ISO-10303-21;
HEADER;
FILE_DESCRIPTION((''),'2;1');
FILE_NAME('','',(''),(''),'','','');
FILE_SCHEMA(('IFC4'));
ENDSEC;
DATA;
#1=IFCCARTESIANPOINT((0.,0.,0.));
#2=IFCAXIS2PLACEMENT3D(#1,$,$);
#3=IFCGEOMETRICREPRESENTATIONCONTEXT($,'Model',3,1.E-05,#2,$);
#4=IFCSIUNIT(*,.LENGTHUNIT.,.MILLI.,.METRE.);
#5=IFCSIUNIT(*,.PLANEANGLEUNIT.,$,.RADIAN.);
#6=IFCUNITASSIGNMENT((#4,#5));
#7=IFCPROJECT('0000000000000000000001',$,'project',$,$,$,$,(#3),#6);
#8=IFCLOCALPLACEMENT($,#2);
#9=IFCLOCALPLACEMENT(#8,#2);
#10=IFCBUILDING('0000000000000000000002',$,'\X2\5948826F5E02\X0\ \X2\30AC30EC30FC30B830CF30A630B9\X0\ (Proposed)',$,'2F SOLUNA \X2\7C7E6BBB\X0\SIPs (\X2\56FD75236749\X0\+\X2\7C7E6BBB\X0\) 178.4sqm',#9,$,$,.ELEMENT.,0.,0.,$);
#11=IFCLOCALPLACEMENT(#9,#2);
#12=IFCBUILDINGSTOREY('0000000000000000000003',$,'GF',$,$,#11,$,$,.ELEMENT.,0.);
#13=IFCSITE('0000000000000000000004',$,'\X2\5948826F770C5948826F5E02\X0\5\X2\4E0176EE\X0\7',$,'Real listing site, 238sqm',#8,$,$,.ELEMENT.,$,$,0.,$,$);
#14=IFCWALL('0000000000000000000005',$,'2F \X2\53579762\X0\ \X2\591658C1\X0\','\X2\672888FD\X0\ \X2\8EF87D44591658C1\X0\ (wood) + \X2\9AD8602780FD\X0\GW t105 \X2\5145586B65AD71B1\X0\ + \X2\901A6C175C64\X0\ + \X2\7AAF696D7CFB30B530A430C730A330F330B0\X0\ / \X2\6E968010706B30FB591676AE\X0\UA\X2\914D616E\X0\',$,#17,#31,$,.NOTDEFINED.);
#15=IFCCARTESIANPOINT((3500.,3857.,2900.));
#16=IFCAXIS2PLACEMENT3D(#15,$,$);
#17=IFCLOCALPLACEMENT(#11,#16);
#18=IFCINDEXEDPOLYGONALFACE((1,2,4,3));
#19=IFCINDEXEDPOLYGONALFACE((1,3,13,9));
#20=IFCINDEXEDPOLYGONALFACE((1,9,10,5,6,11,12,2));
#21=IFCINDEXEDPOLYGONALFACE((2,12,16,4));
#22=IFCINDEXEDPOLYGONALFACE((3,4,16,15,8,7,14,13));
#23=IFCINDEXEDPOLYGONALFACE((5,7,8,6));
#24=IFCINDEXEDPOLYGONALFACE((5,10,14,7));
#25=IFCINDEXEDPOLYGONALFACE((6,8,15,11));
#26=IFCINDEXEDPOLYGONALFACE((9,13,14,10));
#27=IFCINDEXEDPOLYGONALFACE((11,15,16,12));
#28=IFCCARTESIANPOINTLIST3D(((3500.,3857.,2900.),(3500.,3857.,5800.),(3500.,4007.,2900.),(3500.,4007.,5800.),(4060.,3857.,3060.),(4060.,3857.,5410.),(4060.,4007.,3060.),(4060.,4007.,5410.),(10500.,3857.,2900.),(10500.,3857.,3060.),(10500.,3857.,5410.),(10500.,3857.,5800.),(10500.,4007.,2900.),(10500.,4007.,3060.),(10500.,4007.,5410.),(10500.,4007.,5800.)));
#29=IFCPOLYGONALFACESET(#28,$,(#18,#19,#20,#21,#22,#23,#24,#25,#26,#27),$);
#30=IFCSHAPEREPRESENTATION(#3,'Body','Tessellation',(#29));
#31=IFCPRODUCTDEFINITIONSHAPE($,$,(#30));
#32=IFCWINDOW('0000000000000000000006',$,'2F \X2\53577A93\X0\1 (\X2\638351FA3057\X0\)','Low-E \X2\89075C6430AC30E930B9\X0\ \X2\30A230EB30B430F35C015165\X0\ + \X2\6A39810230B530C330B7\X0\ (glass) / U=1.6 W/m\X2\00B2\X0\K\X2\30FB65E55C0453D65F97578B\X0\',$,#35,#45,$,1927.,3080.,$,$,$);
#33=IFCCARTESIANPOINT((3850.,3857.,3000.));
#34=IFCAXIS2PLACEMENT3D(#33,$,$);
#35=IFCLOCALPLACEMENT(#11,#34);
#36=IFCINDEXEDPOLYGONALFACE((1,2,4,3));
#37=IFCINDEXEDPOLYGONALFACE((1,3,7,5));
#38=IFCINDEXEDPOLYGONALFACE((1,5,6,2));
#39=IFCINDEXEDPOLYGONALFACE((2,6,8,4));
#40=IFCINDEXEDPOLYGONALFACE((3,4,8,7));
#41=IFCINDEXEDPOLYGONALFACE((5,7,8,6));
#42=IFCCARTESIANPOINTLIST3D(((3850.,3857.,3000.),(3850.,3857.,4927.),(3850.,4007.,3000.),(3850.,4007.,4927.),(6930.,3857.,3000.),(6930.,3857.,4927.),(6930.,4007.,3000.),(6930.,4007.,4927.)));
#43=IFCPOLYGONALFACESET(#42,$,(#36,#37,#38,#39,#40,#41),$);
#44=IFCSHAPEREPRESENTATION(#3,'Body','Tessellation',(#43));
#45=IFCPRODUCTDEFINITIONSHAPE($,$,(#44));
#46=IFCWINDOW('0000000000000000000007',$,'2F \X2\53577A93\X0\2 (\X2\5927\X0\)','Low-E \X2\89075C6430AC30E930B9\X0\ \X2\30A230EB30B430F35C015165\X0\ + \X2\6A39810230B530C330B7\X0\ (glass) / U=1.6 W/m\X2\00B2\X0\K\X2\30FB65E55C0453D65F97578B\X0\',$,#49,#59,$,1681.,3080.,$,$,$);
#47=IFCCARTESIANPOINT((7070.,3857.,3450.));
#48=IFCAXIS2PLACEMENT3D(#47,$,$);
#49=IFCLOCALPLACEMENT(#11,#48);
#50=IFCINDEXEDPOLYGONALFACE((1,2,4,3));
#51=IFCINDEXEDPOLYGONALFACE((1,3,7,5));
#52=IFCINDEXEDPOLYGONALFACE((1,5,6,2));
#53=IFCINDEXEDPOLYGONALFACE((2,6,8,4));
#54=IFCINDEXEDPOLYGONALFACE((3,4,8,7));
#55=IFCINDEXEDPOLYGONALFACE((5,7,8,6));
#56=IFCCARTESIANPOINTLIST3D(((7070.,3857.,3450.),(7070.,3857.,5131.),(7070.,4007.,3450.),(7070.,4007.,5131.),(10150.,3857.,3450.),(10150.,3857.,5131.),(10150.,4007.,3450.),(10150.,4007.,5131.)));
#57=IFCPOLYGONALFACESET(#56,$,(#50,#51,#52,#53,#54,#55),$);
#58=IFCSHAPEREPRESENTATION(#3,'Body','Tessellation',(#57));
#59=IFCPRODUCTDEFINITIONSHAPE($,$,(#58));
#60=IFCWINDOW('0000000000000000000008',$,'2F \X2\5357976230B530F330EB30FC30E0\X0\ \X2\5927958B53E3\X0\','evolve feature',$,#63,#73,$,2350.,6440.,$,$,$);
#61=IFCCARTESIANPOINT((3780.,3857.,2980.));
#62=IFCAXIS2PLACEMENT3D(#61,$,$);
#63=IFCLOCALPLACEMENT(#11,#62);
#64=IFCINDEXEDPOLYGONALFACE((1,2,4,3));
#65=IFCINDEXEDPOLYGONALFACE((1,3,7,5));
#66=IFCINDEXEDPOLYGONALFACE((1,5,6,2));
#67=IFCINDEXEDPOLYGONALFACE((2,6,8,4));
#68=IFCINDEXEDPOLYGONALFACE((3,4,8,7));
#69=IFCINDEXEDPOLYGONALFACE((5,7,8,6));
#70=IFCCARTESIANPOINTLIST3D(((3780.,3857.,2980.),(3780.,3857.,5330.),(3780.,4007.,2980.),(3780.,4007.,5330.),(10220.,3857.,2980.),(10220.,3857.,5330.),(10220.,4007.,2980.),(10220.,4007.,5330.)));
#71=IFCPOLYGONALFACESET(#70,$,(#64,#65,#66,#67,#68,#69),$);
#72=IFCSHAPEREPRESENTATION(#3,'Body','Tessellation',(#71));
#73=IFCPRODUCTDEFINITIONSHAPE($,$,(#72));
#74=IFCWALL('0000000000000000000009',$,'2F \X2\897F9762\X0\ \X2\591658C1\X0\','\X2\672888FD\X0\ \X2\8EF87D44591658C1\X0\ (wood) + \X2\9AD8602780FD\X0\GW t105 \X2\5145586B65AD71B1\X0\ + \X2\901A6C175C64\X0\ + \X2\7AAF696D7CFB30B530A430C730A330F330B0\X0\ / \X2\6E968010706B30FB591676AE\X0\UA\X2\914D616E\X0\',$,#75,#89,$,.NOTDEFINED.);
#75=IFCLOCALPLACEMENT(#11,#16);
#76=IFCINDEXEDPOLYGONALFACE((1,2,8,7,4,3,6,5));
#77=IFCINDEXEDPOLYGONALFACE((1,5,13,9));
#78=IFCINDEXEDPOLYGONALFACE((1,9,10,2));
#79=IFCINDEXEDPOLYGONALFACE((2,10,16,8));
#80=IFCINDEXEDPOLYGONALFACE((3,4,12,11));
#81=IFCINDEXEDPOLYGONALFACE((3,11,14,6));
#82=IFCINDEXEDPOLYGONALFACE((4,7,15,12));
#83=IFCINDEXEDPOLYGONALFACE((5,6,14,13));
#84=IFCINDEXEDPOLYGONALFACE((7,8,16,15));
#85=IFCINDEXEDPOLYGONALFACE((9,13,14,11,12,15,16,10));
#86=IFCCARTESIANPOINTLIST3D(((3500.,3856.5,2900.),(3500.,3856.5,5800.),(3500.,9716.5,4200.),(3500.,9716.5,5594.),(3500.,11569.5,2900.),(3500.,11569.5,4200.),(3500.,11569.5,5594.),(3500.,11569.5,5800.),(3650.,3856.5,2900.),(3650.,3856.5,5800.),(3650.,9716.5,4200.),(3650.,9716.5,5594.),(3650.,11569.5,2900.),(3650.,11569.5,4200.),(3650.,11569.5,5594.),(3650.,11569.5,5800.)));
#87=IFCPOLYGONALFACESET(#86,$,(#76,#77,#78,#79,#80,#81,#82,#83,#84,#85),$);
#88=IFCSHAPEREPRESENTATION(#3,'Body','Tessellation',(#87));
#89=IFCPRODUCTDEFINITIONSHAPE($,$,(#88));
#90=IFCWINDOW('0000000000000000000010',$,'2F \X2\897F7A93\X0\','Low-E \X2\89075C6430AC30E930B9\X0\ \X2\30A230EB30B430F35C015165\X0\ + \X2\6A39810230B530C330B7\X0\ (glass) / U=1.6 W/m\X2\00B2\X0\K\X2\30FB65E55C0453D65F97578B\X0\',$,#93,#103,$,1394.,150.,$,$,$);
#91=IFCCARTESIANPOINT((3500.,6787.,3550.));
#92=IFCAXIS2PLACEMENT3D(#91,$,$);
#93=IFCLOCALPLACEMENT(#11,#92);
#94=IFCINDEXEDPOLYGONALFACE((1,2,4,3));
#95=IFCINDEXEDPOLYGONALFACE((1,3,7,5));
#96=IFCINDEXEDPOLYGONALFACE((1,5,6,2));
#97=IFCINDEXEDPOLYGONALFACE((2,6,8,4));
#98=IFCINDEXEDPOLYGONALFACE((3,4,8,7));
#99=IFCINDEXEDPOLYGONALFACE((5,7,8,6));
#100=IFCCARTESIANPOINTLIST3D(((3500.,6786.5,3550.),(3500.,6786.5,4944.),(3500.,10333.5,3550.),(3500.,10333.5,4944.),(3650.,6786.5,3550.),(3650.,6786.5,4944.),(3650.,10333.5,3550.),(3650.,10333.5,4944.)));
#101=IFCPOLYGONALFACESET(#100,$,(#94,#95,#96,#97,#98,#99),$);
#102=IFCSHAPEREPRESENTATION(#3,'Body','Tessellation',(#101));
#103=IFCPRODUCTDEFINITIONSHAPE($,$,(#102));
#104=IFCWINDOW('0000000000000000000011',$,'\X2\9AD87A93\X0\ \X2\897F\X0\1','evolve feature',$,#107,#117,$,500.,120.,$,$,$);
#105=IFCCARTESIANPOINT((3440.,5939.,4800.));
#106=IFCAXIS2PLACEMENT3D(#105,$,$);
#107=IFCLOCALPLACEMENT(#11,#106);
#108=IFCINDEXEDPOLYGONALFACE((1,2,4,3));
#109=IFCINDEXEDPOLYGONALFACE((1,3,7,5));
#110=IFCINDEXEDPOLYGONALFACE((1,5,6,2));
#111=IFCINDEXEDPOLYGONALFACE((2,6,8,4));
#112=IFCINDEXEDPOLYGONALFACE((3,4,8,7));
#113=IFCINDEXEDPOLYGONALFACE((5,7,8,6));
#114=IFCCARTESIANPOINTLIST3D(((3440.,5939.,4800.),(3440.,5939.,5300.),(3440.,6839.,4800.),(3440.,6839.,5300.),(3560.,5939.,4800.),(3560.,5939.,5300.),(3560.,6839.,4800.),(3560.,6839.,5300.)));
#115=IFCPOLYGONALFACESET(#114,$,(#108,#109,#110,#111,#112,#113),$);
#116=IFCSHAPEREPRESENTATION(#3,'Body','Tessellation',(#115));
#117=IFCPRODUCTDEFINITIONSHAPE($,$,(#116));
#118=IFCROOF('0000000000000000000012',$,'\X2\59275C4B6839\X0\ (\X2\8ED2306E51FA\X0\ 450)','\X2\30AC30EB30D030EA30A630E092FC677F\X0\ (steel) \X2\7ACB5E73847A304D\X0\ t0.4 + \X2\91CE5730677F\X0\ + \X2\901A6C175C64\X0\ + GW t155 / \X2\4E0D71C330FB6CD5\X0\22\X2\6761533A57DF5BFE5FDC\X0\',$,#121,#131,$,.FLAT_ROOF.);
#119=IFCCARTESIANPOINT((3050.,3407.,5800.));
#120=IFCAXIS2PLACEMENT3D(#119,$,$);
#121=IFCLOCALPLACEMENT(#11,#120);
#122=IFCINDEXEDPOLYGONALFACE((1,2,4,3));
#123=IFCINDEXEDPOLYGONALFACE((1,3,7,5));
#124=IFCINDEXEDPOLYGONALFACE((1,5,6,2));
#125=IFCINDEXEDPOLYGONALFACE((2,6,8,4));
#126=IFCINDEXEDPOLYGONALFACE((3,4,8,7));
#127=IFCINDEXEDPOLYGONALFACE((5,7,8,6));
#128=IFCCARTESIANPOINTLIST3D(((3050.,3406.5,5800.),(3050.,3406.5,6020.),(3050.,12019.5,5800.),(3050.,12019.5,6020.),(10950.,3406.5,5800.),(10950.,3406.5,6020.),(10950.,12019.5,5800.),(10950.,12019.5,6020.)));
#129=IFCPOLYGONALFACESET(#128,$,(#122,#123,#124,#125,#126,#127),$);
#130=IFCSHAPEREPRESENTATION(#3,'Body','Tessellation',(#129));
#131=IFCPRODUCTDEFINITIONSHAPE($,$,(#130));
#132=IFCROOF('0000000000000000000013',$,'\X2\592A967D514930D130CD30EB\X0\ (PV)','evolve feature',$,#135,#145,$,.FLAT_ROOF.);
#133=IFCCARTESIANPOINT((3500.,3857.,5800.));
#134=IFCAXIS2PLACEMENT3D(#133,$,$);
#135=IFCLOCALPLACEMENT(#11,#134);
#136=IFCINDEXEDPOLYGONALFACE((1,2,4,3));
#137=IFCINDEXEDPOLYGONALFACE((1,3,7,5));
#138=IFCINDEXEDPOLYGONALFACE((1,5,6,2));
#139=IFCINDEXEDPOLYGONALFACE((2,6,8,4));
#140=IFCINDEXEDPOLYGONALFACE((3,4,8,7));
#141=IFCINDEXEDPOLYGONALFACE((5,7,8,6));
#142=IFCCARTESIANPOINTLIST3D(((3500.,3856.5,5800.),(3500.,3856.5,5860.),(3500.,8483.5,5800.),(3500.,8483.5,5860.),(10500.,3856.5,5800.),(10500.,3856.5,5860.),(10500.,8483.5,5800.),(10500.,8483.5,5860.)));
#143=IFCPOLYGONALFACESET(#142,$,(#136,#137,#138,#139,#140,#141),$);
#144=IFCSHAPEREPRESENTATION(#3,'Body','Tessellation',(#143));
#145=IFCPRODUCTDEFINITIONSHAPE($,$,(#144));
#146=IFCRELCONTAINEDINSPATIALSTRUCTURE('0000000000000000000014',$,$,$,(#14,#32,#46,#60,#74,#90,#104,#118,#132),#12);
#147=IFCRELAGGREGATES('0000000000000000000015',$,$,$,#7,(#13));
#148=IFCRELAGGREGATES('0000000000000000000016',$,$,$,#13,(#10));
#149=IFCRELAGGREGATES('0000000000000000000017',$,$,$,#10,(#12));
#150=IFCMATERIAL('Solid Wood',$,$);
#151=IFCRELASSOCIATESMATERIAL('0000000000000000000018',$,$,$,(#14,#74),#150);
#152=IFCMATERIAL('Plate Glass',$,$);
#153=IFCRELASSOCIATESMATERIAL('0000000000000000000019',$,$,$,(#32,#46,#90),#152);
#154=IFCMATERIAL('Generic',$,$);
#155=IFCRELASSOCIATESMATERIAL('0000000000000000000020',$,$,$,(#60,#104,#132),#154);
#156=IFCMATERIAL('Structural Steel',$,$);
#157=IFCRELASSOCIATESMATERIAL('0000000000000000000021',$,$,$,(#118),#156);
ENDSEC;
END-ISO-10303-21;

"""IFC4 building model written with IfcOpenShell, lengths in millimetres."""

from ifc_helpers import new_model, si_unit, frame, frame_2d, origin, place, context, project, spatial, rectangle, extrude, material, element, fill, save


model = new_model("IFC4")

# Units and contexts
model_context = context("Model", 3, precision=1e-05, world=origin())
ifc_project = project(units=[si_unit("LENGTHUNIT", "METRE", prefix="MILLI"), si_unit("PLANEANGLEUNIT", "RADIAN")], contexts=[model_context])

# Site, building, storey
site_placement = place(None, origin())
site = spatial("IfcSite", under=ifc_project, at=site_placement, Name="奈良県奈良市5丁目7", ObjectType="Real listing site, 238sqm", CompositionType="ELEMENT", RefElevation=0.0)
building_placement = place(site_placement, origin())
building = spatial("IfcBuilding", under=site, at=building_placement, Name="奈良市 ガレージハウス (Proposed)", ObjectType="2F SOLUNA 籾殻SIPs (国産杉+籾殻) 178.4sqm", CompositionType="ELEMENT", ElevationOfRefHeight=0.0, ElevationOfTerrain=0.0)
storey_placement = place(building_placement, origin())
storey = spatial("IfcBuildingStorey", under=building, at=storey_placement, Name="GF", CompositionType="ELEMENT", Elevation=0.0)

# Shared definitions
ifc_material_1 = material(Name="Solid Wood")
ifc_material_2 = material(Name="Generic")

# Shared definitions
ifc_material_3 = material(Name="Plate Glass")

# Walls, openings, windows
wall_1_placement = place(storey_placement, frame((3500.0, 3857.0, 2900.0)))
wall_1 = element("IfcWall", 1, at=wall_1_placement, inside=storey, material=ifc_material_1, Name="2F 南面 外壁", Description="木製 軸組外壁 (wood) + 高性能GW t105 充填断熱 + 通気層 + 窯業系サイディング / 準耐火・外皮UA配慮", PredefinedType="NOTDEFINED", context=model_context, shape_type="SweptSolid", body=[
    extrude(rectangle(XDim=7000.0, YDim=150.0, at=frame_2d((3500.0, 75.0))), frame((3500.0, 3857.0, 2900.0)), (0.0, 0.0, 1.0), 2900.0),
])
opening_1_placement = place(storey_placement, frame((3850.0, 3857.0, 3000.0)))
opening_1 = element("IfcOpeningElement", 2, at=opening_1_placement, cuts=wall_1, PredefinedType="NOTDEFINED", context=model_context, shape_type="SweptSolid", body=[
    extrude(rectangle(XDim=3080.0, YDim=150.0, at=frame_2d((1540.0, 75.0))), frame((3850.0, 3857.0, 3000.0)), (0.0, 0.0, 1.0), 1927.0),
])
opening_2_placement = place(storey_placement, frame((7070.0, 3857.0, 3450.0)))
opening_2 = element("IfcOpeningElement", 3, at=opening_2_placement, cuts=wall_1, PredefinedType="NOTDEFINED", context=model_context, shape_type="SweptSolid", body=[
    extrude(rectangle(XDim=3080.0, YDim=150.0, at=frame_2d((1540.0, 75.0))), frame((7070.0, 3857.0, 3450.0)), (0.0, 0.0, 1.0), 1681.0),
])
opening_3_placement = place(storey_placement, frame((3780.0, 3857.0, 2980.0)))
opening_3 = element("IfcOpeningElement", 4, at=opening_3_placement, cuts=wall_1, PredefinedType="NOTDEFINED", context=model_context, shape_type="SweptSolid", body=[
    extrude(rectangle(XDim=6440.0, YDim=150.0, at=frame_2d((3220.0, 75.0))), frame((3780.0, 3857.0, 2980.0)), (0.0, 0.0, 1.0), 2350.0),
])
window_1_placement = place(storey_placement, frame((3850.0, 3857.0, 3000.0)))
window_1 = element("IfcWindow", 5, at=window_1_placement, inside=storey, material=ifc_material_3, Name="2F 南窓1 (掃出し)", Description="Low-E 複層ガラス アルゴン封入 + 樹脂サッシ (glass) / U=1.6 W/m²K・日射取得型", OverallHeight=1927.0, OverallWidth=3080.0, context=model_context, shape_type="SweptSolid", body=[
    extrude(rectangle(XDim=3080.0, YDim=150.0, at=frame_2d((1540.0, 75.0))), frame((3850.0, 3857.0, 3000.0)), (0.0, 0.0, 1.0), 1927.0),
])
fill(opening_1, window_1)
window_2_placement = place(storey_placement, frame((7070.0, 3857.0, 3450.0)))
window_2 = element("IfcWindow", 6, at=window_2_placement, inside=storey, material=ifc_material_3, Name="2F 南窓2 (大)", Description="Low-E 複層ガラス アルゴン封入 + 樹脂サッシ (glass) / U=1.6 W/m²K・日射取得型", OverallHeight=1681.0, OverallWidth=3080.0, context=model_context, shape_type="SweptSolid", body=[
    extrude(rectangle(XDim=3080.0, YDim=150.0, at=frame_2d((1540.0, 75.0))), frame((7070.0, 3857.0, 3450.0)), (0.0, 0.0, 1.0), 1681.0),
])
fill(opening_2, window_2)
window_3_placement = place(storey_placement, frame((3780.0, 3857.0, 2980.0)))
window_3 = element("IfcWindow", 7, at=window_3_placement, inside=storey, material=ifc_material_2, Name="2F 南面サンルーム 大開口", Description="evolve feature", OverallHeight=2350.0, OverallWidth=6440.0, context=model_context, shape_type="SweptSolid", body=[
    extrude(rectangle(XDim=6440.0, YDim=150.0, at=frame_2d((3220.0, 75.0))), frame((3780.0, 3857.0, 2980.0)), (0.0, 0.0, 1.0), 2350.0),
])
fill(opening_3, window_3)
wall_2_placement = place(storey_placement, frame((3500.0, 3857.0, 2900.0)))
wall_2 = element("IfcWall", 8, at=wall_2_placement, inside=storey, material=ifc_material_1, Name="2F 西面 外壁", Description="木製 軸組外壁 (wood) + 高性能GW t105 充填断熱 + 通気層 + 窯業系サイディング / 準耐火・外皮UA配慮", PredefinedType="NOTDEFINED", context=model_context, shape_type="SweptSolid", body=[
    extrude(rectangle(XDim=150.0, YDim=7713.0, at=frame_2d((75.0, 3856.0))), frame((3500.0, 3857.0, 2900.0)), (0.0, 0.0, 1.0), 2900.0),
])
opening_4_placement = place(storey_placement, frame((3500.0, 6787.0, 3550.0)))
opening_4 = element("IfcOpeningElement", 9, at=opening_4_placement, cuts=wall_2, PredefinedType="NOTDEFINED", context=model_context, shape_type="SweptSolid", body=[
    extrude(rectangle(XDim=150.0, YDim=3547.0, at=frame_2d((75.0, 1773.0))), frame((3500.0, 6787.0, 3550.0)), (0.0, 0.0, 1.0), 1394.0),
])
opening_5_placement = place(storey_placement, frame((3440.0, 5939.0, 4800.0)))
opening_5 = element("IfcOpeningElement", 10, at=opening_5_placement, cuts=wall_2, PredefinedType="NOTDEFINED", context=model_context, shape_type="SweptSolid", body=[
    extrude(rectangle(XDim=120.0, YDim=900.0, at=frame_2d((60.0, 450.0))), frame((3440.0, 5939.0, 4800.0)), (0.0, 0.0, 1.0), 500.0),
])
window_4_placement = place(storey_placement, frame((3500.0, 6787.0, 3550.0)))
window_4 = element("IfcWindow", 11, at=window_4_placement, inside=storey, material=ifc_material_3, Name="2F 西窓", Description="Low-E 複層ガラス アルゴン封入 + 樹脂サッシ (glass) / U=1.6 W/m²K・日射取得型", OverallHeight=1394.0, OverallWidth=150.0, context=model_context, shape_type="SweptSolid", body=[
    extrude(rectangle(XDim=150.0, YDim=3547.0, at=frame_2d((75.0, 1773.0))), frame((3500.0, 6787.0, 3550.0)), (0.0, 0.0, 1.0), 1394.0),
])
fill(opening_4, window_4)
window_5_placement = place(storey_placement, frame((3440.0, 5939.0, 4800.0)))
window_5 = element("IfcWindow", 12, at=window_5_placement, inside=storey, material=ifc_material_2, Name="高窓 西1", Description="evolve feature", OverallHeight=500.0, OverallWidth=120.0, context=model_context, shape_type="SweptSolid", body=[
    extrude(rectangle(XDim=120.0, YDim=900.0, at=frame_2d((60.0, 450.0))), frame((3440.0, 5939.0, 4800.0)), (0.0, 0.0, 1.0), 500.0),
])
fill(opening_5, window_5)

# Roofs
ifc_material_4 = material(Name="Structural Steel")
roof_1_placement = place(storey_placement, frame((3050.0, 3407.0, 5800.0)))
element("IfcRoof", 13, at=roof_1_placement, inside=storey, material=ifc_material_4, Name="大屋根 (軒の出 450)", Description="ガルバリウム鋼板 (steel) 立平葺き t0.4 + 野地板 + 通気層 + GW t155 / 不燃・法22条区域対応", PredefinedType="FLAT_ROOF", context=model_context, shape_type="SweptSolid", body=[
    extrude(rectangle(XDim=7900.0, YDim=8613.0, at=frame_2d((3950.0, 4306.0))), frame((3050.0, 3407.0, 5800.0)), (0.0, 0.0, 1.0), 220.0),
])
roof_2_placement = place(storey_placement, frame((3500.0, 3857.0, 5800.0)))
element("IfcRoof", 14, at=roof_2_placement, inside=storey, material=ifc_material_2, Name="太陽光パネル (PV)", Description="evolve feature", PredefinedType="FLAT_ROOF", context=model_context, shape_type="SweptSolid", body=[
    extrude(rectangle(XDim=7000.0, YDim=4627.0, at=frame_2d((3500.0, 2313.0))), frame((3500.0, 3857.0, 5800.0)), (0.0, 0.0, 1.0), 60.0),
])

save(model, "model.ifc")
